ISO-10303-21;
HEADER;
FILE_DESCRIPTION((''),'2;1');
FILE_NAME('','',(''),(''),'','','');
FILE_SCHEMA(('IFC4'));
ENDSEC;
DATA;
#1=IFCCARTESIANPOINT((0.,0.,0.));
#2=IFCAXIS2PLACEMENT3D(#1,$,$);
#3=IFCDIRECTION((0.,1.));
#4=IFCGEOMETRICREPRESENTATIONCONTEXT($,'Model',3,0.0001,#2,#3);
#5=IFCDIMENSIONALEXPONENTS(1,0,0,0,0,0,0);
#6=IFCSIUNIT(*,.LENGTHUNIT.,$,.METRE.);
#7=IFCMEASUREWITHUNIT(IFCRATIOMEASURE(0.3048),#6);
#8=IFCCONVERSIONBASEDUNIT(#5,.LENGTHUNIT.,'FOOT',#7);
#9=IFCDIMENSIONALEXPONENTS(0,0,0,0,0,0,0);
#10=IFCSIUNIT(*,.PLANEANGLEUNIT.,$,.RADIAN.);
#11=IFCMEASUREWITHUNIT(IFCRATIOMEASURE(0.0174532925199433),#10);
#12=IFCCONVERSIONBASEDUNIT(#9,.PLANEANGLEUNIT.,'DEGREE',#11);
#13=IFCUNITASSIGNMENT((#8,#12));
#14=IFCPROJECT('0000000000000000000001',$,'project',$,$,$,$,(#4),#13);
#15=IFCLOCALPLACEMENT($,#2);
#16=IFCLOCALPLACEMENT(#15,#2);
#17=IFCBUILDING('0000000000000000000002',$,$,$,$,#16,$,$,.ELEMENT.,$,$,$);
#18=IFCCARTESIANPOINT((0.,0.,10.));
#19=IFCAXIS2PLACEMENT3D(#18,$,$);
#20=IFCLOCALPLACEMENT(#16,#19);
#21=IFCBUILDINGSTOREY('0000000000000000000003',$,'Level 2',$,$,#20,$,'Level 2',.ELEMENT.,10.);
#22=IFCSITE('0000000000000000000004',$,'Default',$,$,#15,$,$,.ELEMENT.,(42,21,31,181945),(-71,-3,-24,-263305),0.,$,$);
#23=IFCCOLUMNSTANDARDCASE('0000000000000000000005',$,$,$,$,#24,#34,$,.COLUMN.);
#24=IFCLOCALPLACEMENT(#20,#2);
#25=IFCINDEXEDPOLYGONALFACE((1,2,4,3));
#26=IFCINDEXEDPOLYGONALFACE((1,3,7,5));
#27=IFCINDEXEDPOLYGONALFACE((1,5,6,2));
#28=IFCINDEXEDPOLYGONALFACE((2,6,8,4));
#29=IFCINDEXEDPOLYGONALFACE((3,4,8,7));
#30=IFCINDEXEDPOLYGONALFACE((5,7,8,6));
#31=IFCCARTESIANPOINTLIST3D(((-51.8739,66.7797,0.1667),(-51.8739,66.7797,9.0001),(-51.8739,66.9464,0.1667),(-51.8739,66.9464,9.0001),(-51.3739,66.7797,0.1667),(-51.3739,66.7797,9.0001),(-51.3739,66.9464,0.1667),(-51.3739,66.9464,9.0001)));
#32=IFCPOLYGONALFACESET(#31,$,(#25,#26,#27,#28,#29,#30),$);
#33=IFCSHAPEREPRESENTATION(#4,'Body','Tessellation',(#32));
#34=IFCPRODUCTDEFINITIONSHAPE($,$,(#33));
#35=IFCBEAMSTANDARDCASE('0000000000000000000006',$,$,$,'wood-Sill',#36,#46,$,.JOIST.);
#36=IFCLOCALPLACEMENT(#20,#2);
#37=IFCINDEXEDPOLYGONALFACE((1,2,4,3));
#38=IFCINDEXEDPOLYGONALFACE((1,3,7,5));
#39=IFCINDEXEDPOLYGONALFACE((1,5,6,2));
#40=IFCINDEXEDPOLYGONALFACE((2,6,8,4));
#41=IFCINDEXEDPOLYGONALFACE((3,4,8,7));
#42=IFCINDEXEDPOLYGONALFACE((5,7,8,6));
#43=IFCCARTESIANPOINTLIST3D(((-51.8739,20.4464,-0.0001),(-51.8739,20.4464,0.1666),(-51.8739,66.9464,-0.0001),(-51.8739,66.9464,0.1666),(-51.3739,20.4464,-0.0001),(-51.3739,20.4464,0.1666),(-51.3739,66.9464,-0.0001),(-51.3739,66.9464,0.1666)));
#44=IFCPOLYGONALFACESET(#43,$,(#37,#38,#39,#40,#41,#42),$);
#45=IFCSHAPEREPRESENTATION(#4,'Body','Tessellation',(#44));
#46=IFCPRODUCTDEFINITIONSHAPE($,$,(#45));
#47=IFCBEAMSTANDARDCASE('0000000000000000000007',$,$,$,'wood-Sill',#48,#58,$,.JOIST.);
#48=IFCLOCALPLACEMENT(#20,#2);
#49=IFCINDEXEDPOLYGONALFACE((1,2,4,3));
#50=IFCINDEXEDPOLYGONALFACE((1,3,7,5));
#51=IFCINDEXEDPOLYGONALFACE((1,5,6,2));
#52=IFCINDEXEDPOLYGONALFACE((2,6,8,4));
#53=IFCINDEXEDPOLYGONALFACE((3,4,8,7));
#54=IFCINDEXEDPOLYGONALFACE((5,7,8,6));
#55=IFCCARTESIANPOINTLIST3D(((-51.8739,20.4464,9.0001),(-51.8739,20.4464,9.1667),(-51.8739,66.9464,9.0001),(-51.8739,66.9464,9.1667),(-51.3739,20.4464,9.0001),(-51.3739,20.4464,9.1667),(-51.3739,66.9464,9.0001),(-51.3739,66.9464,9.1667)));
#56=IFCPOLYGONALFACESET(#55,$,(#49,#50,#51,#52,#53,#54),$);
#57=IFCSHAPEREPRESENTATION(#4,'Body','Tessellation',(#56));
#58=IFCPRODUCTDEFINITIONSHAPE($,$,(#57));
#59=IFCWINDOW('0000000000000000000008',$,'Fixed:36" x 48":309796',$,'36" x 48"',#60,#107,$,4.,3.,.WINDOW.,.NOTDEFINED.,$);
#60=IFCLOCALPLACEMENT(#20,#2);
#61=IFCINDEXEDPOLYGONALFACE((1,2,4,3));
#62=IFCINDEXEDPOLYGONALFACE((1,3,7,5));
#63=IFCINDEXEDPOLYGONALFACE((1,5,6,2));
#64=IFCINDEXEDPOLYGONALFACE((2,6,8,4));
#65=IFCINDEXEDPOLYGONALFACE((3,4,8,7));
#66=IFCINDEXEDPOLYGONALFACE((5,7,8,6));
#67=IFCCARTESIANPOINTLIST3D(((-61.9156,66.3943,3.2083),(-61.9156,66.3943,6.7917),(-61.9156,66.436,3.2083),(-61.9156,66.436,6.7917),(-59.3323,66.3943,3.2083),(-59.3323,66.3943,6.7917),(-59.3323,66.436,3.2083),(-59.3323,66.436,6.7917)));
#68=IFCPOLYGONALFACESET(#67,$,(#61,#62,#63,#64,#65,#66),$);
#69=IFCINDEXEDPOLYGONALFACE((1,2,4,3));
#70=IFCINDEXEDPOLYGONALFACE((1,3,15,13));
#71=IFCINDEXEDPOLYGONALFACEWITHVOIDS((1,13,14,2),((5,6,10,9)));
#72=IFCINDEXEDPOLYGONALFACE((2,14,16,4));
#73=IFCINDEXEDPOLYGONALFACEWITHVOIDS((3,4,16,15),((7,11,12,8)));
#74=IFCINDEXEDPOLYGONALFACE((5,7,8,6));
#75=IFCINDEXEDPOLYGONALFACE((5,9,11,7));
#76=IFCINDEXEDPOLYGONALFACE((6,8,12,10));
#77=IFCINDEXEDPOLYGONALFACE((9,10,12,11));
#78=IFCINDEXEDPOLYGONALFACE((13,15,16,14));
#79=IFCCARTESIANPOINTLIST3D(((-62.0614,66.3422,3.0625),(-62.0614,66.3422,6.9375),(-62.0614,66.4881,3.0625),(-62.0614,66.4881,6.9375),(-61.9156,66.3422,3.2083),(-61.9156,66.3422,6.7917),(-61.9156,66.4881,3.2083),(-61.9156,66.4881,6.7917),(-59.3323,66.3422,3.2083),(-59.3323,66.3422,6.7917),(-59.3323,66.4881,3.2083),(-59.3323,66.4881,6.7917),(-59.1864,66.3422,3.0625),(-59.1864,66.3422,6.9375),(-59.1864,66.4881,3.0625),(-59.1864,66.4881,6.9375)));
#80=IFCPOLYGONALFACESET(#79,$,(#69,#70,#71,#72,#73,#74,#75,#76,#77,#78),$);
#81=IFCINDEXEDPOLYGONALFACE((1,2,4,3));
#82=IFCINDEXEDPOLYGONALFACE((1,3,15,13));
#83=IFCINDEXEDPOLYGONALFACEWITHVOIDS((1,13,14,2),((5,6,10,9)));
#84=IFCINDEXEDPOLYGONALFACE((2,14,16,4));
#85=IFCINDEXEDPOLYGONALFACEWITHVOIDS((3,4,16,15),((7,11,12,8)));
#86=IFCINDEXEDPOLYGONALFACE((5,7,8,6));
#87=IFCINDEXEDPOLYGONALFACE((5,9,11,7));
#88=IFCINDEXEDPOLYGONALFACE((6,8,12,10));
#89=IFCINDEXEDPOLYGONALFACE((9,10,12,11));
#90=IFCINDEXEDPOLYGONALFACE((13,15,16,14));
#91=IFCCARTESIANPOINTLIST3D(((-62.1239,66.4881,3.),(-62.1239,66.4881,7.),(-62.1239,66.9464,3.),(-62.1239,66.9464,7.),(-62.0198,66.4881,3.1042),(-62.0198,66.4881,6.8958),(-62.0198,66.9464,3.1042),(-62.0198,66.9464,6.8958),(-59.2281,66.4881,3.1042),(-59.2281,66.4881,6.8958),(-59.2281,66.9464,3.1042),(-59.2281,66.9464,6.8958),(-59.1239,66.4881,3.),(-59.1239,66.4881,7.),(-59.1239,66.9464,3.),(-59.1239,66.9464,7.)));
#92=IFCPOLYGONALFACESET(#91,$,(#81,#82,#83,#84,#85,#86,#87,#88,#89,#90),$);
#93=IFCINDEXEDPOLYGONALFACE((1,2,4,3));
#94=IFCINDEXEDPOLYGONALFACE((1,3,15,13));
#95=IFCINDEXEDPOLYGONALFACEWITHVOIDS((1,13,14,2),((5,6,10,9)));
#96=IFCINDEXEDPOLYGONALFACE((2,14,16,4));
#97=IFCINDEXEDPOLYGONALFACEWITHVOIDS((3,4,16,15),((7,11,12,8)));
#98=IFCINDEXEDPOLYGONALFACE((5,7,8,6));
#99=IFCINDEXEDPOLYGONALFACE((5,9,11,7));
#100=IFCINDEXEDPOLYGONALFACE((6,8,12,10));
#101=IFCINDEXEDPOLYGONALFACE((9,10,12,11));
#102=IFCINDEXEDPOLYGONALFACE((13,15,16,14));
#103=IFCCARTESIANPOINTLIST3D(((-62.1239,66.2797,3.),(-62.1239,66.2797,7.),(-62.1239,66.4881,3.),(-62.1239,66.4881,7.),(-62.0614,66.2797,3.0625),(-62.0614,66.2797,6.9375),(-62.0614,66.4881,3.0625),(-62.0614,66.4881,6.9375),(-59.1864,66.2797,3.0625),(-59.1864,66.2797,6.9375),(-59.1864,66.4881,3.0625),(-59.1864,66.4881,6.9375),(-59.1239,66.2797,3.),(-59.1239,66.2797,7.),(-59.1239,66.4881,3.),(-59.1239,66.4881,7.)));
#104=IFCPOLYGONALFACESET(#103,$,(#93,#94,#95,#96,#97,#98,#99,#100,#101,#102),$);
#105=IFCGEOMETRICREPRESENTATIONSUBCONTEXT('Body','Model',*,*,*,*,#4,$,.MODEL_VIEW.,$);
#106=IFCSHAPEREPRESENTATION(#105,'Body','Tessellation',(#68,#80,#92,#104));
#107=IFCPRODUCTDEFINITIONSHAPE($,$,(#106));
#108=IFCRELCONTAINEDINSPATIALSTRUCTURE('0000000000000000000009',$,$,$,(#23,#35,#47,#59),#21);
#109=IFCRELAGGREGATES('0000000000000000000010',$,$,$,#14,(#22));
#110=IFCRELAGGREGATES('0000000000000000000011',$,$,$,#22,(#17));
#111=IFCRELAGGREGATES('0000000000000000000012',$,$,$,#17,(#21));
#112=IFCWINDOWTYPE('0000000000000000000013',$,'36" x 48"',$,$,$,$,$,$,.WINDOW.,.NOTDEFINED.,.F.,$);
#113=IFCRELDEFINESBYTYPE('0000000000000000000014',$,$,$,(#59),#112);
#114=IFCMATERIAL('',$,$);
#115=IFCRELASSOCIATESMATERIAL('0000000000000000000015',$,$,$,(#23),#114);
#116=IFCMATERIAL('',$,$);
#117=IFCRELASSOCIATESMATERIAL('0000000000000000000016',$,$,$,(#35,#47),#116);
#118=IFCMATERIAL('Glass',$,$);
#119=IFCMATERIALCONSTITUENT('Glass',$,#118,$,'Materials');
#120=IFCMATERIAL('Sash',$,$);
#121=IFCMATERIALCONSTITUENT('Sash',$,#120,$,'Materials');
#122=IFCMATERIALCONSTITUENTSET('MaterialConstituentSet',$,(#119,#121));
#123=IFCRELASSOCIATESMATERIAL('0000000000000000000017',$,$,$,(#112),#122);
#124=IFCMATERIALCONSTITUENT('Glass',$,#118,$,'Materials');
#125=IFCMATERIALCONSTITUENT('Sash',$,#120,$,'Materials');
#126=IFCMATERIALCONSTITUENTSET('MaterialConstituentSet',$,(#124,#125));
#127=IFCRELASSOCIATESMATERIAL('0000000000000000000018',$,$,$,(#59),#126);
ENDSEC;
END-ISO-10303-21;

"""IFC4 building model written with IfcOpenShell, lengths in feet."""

from ifc_helpers import new_model, entity, si_unit, converted_unit, direction, frame, frame_2d, origin, origin_with_axes, place, context, subcontext, project, spatial, polyline, rectangle, outline, extrude, source, transform, mapped, material, constituent, constituent_set, type_object, type_shapes, element, save


model = new_model("IFC4")

# Units and contexts
model_context = context("Model", 3, precision=0.0001, world=origin(), true_north=direction((0.0, 1.0)))
body_context = subcontext(model_context, "Body", "Model", "MODEL_VIEW")
ifc_project = project(units=[converted_unit("LENGTHUNIT", "FOOT", entity("IfcRatioMeasure", 0.3048), si_unit("LENGTHUNIT", "METRE"), dimensions=[1, 0, 0, 0, 0, 0, 0]), converted_unit("PLANEANGLEUNIT", "DEGREE", entity("IfcRatioMeasure", 0.0174532925199433), si_unit("PLANEANGLEUNIT", "RADIAN"), dimensions=[0, 0, 0, 0, 0, 0, 0])], contexts=[model_context])

# Site, building, storey
site_placement = place(None, origin())
site = spatial("IfcSite", under=ifc_project, at=site_placement, Name="Default", CompositionType="ELEMENT", RefLatitude=(42, 21, 31, 181945), RefLongitude=(-71, -3, -24, -263305), RefElevation=0.0)
building_placement = place(site_placement, origin())
building = spatial("IfcBuilding", under=site, at=building_placement, CompositionType="ELEMENT")
storey_placement = place(building_placement, frame((0.0, 0.0, 10.0)))
storey = spatial("IfcBuildingStorey", under=building, at=storey_placement, Name="Level 2", LongName="Level 2", CompositionType="ELEMENT", Elevation=10.0)

# Column
placement_1 = place(storey_placement, frame((-69.9573, 66.6131, 0.0)))
ifc_material_1 = material(Name="")
placement_2 = place(storey_placement, frame((-51.6239, 66.9464, 0.0), z_axis=(0.0, 0.0, 1.0), x_axis=(0.0, -1.0, 0.0)))
column_placement = place(placement_2, frame((0.0833, 0.0, 0.1667), z_axis=(0.0, 0.0, 1.0), x_axis=(1.0, 0.0, 0.0)))
element("IfcColumnStandardCase", 1, at=column_placement, inside=storey, material=ifc_material_1, PredefinedType="COLUMN", context=model_context, shape_type="SweptSolid", body=[
    extrude(rectangle(XDim=0.1667, YDim=0.5), origin(), (0.0, 0.0, 1.0), 8.8334),
])

# Beams
ifc_material_2 = material(Name="")
for number, where, z_axis, x_axis in (
    (2, (0.0, 0.0, 0.0833), (1.0, 0.0, 0.0), (0.0, 0.0, 1.0)),
    (3, (0.0, 0.0, 9.0834), (1.0, 0.0, 0.0), (0.0, 0.0, 1.0)),
):
    element("IfcBeamStandardCase", number, at=place(placement_2, frame(where, z_axis=z_axis, x_axis=x_axis)), inside=storey, material=ifc_material_2, ObjectType="wood-Sill", PredefinedType="JOIST", context=model_context, shape_type="SweptSolid", body=[
        extrude(rectangle(XDim=0.1667, YDim=0.5), origin_with_axes(), (0.0, 0.0, 1.0), 46.5),
    ])

# Window
ifc_material_3 = material(Name="Glass")
ifc_constituent_1 = constituent(ifc_material_3, Name="Glass", Category="Materials")
ifc_material_4 = material(Name="Sash")
ifc_constituent_2 = constituent(ifc_material_4, Name="Sash", Category="Materials")
ifc_constituent_set_1 = constituent_set(constituents=[ifc_constituent_1, ifc_constituent_2], Name="MaterialConstituentSet")
ifc_constituent_3 = constituent(ifc_material_3, Name="Glass", Category="Materials")
ifc_constituent_4 = constituent(ifc_material_4, Name="Sash", Category="Materials")
ifc_constituent_set_2 = constituent_set(constituents=[ifc_constituent_3, ifc_constituent_4], Name="MaterialConstituentSet")
window_type = type_object("IfcWindowType", Name="36\" x 48\"", ParameterTakesPrecedence=False, PartitioningType="NOTDEFINED", PredefinedType="WINDOW", material=ifc_constituent_set_2)
shared_shape = source(origin(), body_context, "Body", "SweptSolid", [
    extrude(rectangle(XDim=0.0417, YDim=2.5833, at=frame_2d((0.0, 0.0), x_axis=(1.0, 0.0))), frame((1.5, 0.5312, 0.2083), z_axis=(0.0, 0.0, 1.0), x_axis=(0.0, 1.0, 0.0)), (0.0, 0.0, 1.0), 3.5833),
    extrude(outline(polyline([(-1.4375, -1.9375), (1.4375, -1.9375), (1.4375, 1.9375), (-1.4375, 1.9375), (-1.4375, -1.9375)]), holes=[polyline([(-1.2917, -1.7917), (-1.2917, 1.7917), (1.2917, 1.7917), (1.2917, -1.7917), (-1.2917, -1.7917)])]), frame((1.5, 0.4583, 2.0), z_axis=(0.0, 1.0, 0.0), x_axis=(1.0, 0.0, 0.0)), (0.0, 0.0, 1.0), 0.1458),
    extrude(outline(polyline([(-1.5, -2.0), (1.5, -2.0), (1.5, 2.0), (-1.5, 2.0), (-1.5, -2.0)]), holes=[polyline([(-1.3958, -1.8958), (-1.3958, 1.8958), (1.3958, 1.8958), (1.3958, -1.8958), (-1.3958, -1.8958)])]), frame((1.5, 0.0, 2.0), z_axis=(0.0, 1.0, 0.0), x_axis=(1.0, 0.0, 0.0)), (0.0, 0.0, 1.0), 0.4583),
    extrude(outline(polyline([(-2.0, -1.5), (2.0, -1.5), (2.0, 1.5), (-2.0, 1.5), (-2.0, -1.5)]), holes=[polyline([(-1.9375, -1.4375), (-1.9375, 1.4375), (1.9375, 1.4375), (1.9375, -1.4375), (-1.9375, -1.4375)])]), frame((1.5, 0.4583, 2.0), z_axis=(0.0, 1.0, 0.0), x_axis=(0.0, 0.0, -1.0)), (0.0, 0.0, 1.0), 0.2083),
])
type_shapes(window_type, [shared_shape])
placement_3 = place(placement_1, frame((10.8333, 0.3333, 3.0)))
window_placement = place(placement_3, frame((0.0, 0.0, 0.0), z_axis=(0.0, 0.0, 1.0), x_axis=(-1.0, 0.0, 0.0)))
element("IfcWindow", 4, at=window_placement, inside=storey, type_object=window_type, material=ifc_constituent_set_1, Name="Fixed:36\" x 48\":309796", ObjectType="36\" x 48\"", OverallHeight=4.0, OverallWidth=3.0, PartitioningType="NOTDEFINED", PredefinedType="WINDOW", context=body_context, shape_type="MappedRepresentation", body=[
    mapped(shared_shape, transform((0.0, 0.0, 0.0), scale=1.0)),
])

save(model, "model.ifc")
